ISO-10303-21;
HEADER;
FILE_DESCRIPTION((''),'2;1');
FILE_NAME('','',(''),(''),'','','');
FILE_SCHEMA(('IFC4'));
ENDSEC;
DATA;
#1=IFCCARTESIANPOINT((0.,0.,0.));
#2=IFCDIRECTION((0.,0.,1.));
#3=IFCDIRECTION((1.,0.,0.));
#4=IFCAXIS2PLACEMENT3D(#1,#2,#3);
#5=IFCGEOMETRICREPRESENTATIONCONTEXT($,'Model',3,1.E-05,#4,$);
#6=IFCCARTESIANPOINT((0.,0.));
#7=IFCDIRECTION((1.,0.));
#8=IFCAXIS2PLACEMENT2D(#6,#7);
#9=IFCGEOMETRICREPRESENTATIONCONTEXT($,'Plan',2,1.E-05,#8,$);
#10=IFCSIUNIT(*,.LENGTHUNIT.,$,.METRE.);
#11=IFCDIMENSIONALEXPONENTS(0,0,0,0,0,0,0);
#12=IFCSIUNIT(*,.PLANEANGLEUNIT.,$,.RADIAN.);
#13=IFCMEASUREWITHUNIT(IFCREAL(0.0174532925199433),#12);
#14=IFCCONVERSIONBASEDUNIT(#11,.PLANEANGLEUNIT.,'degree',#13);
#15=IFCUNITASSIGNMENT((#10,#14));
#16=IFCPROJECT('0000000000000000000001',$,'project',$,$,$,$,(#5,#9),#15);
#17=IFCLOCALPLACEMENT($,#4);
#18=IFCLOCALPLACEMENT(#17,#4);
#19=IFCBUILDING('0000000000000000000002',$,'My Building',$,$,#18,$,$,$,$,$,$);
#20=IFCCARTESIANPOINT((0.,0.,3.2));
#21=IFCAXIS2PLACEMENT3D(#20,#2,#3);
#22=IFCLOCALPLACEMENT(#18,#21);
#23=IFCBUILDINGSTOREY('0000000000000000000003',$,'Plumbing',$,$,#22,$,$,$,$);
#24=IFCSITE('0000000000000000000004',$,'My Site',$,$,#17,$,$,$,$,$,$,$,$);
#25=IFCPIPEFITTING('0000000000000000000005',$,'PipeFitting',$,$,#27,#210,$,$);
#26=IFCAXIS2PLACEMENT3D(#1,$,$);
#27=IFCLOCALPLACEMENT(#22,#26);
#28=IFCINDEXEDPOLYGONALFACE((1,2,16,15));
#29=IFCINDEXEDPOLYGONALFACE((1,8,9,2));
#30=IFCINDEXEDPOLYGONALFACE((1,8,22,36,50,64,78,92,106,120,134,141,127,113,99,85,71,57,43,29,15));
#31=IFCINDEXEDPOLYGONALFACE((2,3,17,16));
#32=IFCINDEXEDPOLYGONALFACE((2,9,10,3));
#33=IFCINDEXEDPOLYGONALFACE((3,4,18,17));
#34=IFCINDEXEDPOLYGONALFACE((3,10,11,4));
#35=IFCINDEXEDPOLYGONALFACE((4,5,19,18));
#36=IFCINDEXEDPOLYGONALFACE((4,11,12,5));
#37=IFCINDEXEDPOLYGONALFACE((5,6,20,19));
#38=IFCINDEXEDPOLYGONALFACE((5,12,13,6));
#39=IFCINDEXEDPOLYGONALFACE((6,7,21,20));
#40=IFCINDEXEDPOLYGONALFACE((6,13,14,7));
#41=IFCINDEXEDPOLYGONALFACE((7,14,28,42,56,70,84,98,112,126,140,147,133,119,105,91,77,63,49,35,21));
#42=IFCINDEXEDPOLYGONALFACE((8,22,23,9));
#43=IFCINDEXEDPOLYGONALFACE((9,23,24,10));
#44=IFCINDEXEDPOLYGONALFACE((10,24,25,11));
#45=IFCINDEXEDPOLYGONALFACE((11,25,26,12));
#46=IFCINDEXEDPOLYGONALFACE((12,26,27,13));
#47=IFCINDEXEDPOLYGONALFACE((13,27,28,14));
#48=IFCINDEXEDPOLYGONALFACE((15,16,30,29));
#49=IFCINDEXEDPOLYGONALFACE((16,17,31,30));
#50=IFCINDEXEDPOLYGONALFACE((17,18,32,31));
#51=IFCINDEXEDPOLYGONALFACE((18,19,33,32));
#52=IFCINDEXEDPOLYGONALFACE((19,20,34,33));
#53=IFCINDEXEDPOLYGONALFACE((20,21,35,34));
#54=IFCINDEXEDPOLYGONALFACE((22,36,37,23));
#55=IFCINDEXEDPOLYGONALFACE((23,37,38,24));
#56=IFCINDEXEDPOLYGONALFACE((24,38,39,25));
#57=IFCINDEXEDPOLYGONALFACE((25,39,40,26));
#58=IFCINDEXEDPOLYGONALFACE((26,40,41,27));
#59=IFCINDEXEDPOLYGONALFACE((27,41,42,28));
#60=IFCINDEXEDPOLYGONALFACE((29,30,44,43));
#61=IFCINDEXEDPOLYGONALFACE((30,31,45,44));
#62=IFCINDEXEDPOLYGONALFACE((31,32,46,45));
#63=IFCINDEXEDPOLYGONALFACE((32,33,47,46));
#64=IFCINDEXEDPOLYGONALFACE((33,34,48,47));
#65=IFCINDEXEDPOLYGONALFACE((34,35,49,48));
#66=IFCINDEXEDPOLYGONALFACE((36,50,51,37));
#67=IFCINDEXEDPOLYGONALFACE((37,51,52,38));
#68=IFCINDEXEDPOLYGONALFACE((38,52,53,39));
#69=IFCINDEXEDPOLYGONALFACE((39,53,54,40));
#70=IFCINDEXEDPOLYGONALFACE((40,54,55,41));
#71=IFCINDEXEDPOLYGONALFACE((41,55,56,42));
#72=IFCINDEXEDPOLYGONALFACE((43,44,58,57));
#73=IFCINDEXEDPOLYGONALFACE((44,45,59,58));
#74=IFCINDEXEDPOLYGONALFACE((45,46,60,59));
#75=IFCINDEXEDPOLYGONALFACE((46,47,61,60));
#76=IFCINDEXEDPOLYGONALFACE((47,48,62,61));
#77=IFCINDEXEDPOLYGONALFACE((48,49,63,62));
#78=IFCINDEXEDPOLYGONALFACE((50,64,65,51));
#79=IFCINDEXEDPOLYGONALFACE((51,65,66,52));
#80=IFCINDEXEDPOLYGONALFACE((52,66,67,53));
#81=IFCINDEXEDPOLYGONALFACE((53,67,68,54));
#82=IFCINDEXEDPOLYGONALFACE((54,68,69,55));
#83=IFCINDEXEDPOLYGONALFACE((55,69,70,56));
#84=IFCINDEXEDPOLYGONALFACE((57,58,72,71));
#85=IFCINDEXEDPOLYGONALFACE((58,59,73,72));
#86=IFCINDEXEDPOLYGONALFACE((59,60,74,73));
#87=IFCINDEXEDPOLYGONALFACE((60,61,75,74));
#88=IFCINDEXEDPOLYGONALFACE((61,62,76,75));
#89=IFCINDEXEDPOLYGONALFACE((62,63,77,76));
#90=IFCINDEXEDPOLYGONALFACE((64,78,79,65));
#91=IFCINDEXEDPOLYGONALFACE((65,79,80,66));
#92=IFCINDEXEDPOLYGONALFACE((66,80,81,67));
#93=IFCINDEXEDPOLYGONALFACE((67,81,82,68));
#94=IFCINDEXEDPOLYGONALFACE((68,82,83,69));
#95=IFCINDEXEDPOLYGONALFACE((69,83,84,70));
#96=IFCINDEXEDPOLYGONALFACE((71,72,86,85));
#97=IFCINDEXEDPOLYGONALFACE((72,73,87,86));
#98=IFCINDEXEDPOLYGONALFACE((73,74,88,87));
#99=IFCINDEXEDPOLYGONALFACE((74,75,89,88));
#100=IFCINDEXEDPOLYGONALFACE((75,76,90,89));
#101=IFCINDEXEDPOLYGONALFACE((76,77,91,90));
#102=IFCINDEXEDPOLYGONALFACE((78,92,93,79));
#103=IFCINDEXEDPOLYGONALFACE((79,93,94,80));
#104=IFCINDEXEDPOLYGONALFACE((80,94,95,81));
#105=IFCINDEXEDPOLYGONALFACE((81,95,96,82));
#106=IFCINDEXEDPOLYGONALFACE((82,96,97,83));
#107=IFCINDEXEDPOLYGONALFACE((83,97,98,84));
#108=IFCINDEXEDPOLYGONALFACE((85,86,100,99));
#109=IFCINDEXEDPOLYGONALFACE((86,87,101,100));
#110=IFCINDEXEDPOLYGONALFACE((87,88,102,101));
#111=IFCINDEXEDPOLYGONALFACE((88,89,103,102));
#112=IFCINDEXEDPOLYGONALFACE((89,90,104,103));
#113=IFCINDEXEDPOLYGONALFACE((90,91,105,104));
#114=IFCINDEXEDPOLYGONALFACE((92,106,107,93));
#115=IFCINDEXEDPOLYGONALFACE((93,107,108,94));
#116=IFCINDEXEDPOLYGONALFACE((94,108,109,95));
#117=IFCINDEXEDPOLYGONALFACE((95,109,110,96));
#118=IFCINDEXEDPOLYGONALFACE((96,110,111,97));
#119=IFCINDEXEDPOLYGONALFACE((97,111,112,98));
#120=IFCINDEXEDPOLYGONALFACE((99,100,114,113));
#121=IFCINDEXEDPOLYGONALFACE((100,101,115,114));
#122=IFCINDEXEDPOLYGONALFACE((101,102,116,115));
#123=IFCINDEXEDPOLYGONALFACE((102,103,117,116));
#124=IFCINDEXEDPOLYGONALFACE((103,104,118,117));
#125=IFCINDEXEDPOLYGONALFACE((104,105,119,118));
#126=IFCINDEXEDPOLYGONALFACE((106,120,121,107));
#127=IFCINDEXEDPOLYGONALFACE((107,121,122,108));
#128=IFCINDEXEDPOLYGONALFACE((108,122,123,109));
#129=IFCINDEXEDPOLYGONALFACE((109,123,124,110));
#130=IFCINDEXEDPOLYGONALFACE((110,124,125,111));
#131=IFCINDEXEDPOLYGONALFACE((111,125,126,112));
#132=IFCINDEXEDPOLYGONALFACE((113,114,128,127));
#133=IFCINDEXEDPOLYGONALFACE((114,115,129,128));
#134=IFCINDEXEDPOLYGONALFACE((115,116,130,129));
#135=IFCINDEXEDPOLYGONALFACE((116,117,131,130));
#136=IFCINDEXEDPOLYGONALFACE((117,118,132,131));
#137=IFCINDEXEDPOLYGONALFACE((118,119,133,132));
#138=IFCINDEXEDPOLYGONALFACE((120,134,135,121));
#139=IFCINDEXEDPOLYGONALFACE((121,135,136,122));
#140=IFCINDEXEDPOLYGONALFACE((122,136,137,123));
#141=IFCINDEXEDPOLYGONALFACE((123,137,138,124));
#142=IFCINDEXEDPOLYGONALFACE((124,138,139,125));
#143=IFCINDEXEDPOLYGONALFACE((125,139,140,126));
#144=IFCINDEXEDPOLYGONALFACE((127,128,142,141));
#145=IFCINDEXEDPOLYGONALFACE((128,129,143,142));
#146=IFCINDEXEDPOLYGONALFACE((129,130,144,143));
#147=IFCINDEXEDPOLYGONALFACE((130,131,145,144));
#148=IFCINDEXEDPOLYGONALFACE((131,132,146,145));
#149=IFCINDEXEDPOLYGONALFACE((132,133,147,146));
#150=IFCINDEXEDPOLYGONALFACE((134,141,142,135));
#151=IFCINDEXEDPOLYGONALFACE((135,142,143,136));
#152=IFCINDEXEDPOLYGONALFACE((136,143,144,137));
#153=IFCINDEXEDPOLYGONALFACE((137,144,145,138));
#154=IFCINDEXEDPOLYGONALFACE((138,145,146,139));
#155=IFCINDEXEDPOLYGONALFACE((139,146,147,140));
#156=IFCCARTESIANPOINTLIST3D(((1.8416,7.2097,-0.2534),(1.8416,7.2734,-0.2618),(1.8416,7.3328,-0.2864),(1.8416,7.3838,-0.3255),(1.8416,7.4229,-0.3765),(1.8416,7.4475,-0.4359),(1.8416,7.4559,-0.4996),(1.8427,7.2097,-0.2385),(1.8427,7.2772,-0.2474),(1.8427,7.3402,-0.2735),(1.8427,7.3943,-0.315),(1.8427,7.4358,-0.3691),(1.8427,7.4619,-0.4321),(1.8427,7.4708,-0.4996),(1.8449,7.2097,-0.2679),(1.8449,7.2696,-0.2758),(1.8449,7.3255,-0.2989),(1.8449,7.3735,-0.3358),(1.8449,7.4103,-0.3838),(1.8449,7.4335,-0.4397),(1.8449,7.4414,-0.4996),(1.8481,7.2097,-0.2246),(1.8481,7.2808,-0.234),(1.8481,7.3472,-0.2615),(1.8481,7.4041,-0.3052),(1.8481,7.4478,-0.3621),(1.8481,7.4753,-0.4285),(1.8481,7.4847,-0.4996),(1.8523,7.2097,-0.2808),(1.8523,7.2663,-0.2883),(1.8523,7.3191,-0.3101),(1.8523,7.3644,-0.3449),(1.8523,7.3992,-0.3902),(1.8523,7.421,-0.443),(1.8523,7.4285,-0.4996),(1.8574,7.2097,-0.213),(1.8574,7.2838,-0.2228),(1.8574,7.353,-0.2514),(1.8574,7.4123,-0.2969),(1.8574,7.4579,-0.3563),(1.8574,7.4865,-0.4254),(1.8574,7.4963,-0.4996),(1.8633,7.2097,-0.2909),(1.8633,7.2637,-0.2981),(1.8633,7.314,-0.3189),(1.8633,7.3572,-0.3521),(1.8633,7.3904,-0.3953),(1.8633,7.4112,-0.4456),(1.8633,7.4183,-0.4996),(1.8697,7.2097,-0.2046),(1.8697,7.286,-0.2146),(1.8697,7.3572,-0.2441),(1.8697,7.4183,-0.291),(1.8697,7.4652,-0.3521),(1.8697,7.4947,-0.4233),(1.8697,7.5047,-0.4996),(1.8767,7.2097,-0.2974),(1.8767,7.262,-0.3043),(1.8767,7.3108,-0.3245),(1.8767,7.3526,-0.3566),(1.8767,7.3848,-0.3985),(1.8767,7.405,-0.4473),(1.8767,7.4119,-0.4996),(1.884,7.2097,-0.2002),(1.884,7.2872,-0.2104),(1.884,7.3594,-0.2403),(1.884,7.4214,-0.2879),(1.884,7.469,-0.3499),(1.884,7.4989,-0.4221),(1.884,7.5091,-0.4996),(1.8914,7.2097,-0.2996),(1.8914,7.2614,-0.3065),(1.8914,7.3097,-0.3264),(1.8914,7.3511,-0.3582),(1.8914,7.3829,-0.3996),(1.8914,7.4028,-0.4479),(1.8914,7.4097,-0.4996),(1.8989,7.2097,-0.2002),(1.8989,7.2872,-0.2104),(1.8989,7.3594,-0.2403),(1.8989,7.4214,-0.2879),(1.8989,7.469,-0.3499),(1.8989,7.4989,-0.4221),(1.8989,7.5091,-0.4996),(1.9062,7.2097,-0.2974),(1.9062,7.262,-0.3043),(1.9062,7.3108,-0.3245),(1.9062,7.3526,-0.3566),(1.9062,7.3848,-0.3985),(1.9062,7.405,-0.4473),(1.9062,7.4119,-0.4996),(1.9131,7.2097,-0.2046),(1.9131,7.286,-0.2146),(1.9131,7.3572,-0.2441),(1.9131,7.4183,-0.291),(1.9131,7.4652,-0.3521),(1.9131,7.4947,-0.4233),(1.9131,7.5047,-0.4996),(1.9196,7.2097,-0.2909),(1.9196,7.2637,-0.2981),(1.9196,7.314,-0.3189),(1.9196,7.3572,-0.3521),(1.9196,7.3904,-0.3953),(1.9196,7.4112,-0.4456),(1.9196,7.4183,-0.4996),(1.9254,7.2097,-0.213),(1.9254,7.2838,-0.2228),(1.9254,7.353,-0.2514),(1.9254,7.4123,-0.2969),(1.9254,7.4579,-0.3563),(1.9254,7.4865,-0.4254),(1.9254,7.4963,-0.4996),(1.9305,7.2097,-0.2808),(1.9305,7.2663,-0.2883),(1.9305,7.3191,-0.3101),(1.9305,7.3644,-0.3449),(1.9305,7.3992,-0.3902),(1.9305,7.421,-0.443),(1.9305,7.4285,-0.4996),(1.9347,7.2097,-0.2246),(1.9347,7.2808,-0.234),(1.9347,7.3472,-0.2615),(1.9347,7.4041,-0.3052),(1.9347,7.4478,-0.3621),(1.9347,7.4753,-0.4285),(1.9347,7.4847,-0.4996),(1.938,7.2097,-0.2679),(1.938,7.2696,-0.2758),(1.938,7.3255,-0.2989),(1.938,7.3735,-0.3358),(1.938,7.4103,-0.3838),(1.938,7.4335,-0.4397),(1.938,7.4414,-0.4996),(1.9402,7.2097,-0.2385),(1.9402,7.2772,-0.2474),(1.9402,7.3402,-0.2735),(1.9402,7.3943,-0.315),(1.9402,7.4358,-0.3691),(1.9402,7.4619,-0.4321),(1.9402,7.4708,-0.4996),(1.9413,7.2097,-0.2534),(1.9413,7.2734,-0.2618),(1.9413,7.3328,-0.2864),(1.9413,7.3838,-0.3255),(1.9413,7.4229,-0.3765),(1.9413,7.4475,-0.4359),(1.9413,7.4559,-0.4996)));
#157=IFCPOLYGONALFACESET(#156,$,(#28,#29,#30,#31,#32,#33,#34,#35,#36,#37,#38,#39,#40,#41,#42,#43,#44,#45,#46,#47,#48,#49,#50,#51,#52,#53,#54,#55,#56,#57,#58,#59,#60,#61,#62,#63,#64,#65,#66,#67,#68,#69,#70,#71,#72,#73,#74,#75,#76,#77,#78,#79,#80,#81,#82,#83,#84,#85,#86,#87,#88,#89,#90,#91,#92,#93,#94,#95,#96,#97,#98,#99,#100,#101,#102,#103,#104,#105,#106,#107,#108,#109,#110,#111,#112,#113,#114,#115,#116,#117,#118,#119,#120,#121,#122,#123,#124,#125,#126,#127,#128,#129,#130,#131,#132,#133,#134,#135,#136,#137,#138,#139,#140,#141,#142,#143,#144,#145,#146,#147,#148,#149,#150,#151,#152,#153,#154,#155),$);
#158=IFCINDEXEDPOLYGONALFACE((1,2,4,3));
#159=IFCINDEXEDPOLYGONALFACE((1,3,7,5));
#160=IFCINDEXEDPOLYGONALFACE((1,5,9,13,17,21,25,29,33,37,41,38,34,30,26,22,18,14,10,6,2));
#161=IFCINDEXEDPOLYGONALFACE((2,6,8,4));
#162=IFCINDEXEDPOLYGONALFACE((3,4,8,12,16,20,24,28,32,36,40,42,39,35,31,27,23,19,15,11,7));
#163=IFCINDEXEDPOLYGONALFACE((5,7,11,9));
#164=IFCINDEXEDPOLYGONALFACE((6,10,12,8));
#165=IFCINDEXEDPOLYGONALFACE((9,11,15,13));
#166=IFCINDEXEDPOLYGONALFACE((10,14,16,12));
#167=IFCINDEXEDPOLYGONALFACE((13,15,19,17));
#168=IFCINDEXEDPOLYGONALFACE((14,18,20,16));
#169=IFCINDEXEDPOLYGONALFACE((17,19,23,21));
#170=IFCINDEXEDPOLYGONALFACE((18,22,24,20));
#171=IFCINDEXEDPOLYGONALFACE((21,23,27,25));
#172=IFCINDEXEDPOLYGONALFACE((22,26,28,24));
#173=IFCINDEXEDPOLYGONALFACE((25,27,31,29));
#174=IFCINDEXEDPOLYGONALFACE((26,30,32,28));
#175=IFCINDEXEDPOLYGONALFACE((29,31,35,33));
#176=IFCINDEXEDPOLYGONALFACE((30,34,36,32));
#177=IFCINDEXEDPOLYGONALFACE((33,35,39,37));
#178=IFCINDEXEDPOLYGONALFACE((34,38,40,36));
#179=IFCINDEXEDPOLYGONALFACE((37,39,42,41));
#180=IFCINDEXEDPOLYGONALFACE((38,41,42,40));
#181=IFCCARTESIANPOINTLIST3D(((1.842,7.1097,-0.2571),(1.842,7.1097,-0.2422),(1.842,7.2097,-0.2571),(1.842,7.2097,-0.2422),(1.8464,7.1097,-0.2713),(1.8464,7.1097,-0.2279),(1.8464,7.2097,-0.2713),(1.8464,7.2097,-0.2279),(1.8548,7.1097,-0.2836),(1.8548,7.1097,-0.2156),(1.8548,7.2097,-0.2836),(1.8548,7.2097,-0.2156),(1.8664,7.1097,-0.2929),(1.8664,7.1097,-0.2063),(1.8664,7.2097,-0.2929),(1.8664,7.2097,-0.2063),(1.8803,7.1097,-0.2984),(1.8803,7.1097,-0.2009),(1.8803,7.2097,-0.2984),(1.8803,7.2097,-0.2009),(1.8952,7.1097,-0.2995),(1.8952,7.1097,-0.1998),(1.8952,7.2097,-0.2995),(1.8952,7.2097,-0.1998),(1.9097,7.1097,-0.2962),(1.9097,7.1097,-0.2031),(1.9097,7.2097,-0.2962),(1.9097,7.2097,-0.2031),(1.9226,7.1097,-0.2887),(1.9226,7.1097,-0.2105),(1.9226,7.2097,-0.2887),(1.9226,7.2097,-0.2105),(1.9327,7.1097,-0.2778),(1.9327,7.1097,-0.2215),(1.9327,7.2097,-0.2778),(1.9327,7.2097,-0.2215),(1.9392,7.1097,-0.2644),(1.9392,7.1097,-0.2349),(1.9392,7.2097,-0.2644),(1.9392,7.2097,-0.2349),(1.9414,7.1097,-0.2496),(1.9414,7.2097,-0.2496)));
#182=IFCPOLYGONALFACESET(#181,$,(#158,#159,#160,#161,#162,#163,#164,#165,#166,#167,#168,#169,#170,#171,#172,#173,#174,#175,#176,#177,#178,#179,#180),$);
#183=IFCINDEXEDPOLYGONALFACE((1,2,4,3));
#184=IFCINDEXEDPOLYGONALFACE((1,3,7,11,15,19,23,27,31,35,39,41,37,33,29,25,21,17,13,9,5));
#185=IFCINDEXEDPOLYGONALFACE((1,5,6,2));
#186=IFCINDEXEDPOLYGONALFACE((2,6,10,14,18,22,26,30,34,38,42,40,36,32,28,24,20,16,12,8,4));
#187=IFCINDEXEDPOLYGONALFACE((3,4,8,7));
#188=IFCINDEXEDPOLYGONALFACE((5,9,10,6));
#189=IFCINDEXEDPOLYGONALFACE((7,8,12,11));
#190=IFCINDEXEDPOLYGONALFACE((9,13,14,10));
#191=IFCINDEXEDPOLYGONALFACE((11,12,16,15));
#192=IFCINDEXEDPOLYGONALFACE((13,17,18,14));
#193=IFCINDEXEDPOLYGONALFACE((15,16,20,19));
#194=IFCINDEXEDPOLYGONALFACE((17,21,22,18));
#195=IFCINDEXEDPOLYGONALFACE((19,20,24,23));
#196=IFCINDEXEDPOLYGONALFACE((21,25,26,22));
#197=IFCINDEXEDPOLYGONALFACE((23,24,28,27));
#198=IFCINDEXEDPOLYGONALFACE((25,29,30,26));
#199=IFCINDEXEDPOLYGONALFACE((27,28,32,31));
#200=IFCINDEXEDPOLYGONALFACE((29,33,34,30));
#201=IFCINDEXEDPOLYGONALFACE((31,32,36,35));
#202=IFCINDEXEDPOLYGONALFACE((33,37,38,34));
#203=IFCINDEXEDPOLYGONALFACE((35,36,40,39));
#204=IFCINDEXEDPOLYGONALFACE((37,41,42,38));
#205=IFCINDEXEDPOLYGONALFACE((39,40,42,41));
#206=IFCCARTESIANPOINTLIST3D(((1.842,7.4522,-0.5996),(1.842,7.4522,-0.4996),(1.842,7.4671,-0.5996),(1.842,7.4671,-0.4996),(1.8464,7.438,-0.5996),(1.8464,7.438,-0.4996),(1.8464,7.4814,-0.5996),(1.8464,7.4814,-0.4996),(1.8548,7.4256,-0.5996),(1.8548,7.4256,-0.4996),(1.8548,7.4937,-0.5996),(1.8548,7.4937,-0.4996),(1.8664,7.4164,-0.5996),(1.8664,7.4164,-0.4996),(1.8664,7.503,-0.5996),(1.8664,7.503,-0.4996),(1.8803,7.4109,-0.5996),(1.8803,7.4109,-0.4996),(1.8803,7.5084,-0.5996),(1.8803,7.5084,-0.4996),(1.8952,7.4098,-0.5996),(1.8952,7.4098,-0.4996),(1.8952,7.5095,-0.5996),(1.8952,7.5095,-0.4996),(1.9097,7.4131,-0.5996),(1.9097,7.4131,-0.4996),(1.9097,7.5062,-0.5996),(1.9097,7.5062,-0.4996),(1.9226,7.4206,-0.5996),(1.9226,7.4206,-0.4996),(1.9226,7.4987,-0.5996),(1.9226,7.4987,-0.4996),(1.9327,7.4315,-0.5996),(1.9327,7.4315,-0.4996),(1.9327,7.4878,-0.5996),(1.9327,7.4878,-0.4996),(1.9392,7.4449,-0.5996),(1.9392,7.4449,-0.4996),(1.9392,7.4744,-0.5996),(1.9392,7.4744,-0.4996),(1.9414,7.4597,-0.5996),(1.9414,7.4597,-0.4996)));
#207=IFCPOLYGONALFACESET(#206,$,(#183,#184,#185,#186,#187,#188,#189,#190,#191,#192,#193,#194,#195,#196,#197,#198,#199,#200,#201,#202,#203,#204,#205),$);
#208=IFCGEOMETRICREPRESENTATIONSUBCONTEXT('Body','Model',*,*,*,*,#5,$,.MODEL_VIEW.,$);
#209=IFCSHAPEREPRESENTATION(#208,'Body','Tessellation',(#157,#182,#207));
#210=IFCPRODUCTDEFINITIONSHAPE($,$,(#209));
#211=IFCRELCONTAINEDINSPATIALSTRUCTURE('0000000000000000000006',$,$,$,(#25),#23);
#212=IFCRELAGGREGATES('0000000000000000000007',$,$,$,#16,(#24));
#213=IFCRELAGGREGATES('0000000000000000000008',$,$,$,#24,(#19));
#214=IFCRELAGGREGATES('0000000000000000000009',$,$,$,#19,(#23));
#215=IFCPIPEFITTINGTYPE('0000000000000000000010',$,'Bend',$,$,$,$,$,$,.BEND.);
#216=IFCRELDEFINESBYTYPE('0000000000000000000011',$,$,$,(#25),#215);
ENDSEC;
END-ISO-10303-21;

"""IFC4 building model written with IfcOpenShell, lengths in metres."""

from ifc_helpers import new_model, entity, si_unit, converted_unit, frame, origin_with_axes, origin_2d_with_axis, place, context, subcontext, project, spatial, circle, extrude, source, transform, mapped, type_object, type_shapes, element, save


model = new_model("IFC4")

# Units and contexts
model_context = context("Model", 3, precision=1e-05, world=origin_with_axes())
plan_context = context("Plan", 2, precision=1e-05, world=origin_2d_with_axis())
body_context = subcontext(model_context, "Body", "Model", "MODEL_VIEW")
ifc_project = project(units=[si_unit("LENGTHUNIT", "METRE"), converted_unit("PLANEANGLEUNIT", "degree", entity("IfcReal", 0.0174532925199433), si_unit("PLANEANGLEUNIT", "RADIAN"), dimensions=[0, 0, 0, 0, 0, 0, 0])], contexts=[model_context, plan_context])

# Site, building, storey
site_placement = place(None, origin_with_axes())
site = spatial("IfcSite", under=ifc_project, at=site_placement, Name="My Site")
building_placement = place(site_placement, origin_with_axes())
building = spatial("IfcBuilding", under=site, at=building_placement, Name="My Building")
storey_placement = place(building_placement, frame((0.0, 0.0, 3.2), z_axis=(0.0, 0.0, 1.0), x_axis=(1.0, 0.0, 0.0)))
storey = spatial("IfcBuildingStorey", under=building, at=storey_placement, Name="Plumbing")

# Pipe fitting
pipe_fitting_type = type_object("IfcPipeFittingType", Name="Bend", PredefinedType="BEND")
shared_shape = source(origin_with_axes(), body_context, "Body", "SolidModel", [
    entity("IfcSweptDiskSolid", entity("IfcIndexedPolyCurve", entity("IfcCartesianPointList3D", [[0.0, 0.0, -0.1], [0.0, -0.0732, -0.2768], [0.0, -0.25, -0.35]]), [entity("IfcArcIndex", [1, 2, 3])]), 0.05),
    extrude(circle(Radius=0.05), origin_with_axes(), (0.0, 0.0, -1.0), 0.1),
    extrude(circle(Radius=0.05), frame((0.0, -0.25, -0.35), z_axis=(0.0, -1.0, 0.0), x_axis=(1.0, 0.0, 0.0)), (0.0, 0.0, 1.0), 0.1),
])
type_shapes(pipe_fitting_type, [shared_shape])
for number, where, z_axis, x_axis, name in (
    (1, (1.8914, 7.1097, -0.2496), (0.0, -1.0, 0.0), (1.0, 0.0, 0.0), "PipeFitting"),
):
    element("IfcPipeFitting", number, at=place(storey_placement, frame(where, z_axis=z_axis, x_axis=x_axis)), inside=storey, type_object=pipe_fitting_type, Name=name, context=body_context, shape_type="MappedRepresentation", body=[
        mapped(shared_shape, transform((0.0, 0.0, 0.0), x_axis=(1.0, 0.0, 0.0), y_axis=(0.0, 1.0, 0.0), z_axis=(0.0, 0.0, 1.0), scale=1.0)),
    ])

save(model, "model.ifc")
